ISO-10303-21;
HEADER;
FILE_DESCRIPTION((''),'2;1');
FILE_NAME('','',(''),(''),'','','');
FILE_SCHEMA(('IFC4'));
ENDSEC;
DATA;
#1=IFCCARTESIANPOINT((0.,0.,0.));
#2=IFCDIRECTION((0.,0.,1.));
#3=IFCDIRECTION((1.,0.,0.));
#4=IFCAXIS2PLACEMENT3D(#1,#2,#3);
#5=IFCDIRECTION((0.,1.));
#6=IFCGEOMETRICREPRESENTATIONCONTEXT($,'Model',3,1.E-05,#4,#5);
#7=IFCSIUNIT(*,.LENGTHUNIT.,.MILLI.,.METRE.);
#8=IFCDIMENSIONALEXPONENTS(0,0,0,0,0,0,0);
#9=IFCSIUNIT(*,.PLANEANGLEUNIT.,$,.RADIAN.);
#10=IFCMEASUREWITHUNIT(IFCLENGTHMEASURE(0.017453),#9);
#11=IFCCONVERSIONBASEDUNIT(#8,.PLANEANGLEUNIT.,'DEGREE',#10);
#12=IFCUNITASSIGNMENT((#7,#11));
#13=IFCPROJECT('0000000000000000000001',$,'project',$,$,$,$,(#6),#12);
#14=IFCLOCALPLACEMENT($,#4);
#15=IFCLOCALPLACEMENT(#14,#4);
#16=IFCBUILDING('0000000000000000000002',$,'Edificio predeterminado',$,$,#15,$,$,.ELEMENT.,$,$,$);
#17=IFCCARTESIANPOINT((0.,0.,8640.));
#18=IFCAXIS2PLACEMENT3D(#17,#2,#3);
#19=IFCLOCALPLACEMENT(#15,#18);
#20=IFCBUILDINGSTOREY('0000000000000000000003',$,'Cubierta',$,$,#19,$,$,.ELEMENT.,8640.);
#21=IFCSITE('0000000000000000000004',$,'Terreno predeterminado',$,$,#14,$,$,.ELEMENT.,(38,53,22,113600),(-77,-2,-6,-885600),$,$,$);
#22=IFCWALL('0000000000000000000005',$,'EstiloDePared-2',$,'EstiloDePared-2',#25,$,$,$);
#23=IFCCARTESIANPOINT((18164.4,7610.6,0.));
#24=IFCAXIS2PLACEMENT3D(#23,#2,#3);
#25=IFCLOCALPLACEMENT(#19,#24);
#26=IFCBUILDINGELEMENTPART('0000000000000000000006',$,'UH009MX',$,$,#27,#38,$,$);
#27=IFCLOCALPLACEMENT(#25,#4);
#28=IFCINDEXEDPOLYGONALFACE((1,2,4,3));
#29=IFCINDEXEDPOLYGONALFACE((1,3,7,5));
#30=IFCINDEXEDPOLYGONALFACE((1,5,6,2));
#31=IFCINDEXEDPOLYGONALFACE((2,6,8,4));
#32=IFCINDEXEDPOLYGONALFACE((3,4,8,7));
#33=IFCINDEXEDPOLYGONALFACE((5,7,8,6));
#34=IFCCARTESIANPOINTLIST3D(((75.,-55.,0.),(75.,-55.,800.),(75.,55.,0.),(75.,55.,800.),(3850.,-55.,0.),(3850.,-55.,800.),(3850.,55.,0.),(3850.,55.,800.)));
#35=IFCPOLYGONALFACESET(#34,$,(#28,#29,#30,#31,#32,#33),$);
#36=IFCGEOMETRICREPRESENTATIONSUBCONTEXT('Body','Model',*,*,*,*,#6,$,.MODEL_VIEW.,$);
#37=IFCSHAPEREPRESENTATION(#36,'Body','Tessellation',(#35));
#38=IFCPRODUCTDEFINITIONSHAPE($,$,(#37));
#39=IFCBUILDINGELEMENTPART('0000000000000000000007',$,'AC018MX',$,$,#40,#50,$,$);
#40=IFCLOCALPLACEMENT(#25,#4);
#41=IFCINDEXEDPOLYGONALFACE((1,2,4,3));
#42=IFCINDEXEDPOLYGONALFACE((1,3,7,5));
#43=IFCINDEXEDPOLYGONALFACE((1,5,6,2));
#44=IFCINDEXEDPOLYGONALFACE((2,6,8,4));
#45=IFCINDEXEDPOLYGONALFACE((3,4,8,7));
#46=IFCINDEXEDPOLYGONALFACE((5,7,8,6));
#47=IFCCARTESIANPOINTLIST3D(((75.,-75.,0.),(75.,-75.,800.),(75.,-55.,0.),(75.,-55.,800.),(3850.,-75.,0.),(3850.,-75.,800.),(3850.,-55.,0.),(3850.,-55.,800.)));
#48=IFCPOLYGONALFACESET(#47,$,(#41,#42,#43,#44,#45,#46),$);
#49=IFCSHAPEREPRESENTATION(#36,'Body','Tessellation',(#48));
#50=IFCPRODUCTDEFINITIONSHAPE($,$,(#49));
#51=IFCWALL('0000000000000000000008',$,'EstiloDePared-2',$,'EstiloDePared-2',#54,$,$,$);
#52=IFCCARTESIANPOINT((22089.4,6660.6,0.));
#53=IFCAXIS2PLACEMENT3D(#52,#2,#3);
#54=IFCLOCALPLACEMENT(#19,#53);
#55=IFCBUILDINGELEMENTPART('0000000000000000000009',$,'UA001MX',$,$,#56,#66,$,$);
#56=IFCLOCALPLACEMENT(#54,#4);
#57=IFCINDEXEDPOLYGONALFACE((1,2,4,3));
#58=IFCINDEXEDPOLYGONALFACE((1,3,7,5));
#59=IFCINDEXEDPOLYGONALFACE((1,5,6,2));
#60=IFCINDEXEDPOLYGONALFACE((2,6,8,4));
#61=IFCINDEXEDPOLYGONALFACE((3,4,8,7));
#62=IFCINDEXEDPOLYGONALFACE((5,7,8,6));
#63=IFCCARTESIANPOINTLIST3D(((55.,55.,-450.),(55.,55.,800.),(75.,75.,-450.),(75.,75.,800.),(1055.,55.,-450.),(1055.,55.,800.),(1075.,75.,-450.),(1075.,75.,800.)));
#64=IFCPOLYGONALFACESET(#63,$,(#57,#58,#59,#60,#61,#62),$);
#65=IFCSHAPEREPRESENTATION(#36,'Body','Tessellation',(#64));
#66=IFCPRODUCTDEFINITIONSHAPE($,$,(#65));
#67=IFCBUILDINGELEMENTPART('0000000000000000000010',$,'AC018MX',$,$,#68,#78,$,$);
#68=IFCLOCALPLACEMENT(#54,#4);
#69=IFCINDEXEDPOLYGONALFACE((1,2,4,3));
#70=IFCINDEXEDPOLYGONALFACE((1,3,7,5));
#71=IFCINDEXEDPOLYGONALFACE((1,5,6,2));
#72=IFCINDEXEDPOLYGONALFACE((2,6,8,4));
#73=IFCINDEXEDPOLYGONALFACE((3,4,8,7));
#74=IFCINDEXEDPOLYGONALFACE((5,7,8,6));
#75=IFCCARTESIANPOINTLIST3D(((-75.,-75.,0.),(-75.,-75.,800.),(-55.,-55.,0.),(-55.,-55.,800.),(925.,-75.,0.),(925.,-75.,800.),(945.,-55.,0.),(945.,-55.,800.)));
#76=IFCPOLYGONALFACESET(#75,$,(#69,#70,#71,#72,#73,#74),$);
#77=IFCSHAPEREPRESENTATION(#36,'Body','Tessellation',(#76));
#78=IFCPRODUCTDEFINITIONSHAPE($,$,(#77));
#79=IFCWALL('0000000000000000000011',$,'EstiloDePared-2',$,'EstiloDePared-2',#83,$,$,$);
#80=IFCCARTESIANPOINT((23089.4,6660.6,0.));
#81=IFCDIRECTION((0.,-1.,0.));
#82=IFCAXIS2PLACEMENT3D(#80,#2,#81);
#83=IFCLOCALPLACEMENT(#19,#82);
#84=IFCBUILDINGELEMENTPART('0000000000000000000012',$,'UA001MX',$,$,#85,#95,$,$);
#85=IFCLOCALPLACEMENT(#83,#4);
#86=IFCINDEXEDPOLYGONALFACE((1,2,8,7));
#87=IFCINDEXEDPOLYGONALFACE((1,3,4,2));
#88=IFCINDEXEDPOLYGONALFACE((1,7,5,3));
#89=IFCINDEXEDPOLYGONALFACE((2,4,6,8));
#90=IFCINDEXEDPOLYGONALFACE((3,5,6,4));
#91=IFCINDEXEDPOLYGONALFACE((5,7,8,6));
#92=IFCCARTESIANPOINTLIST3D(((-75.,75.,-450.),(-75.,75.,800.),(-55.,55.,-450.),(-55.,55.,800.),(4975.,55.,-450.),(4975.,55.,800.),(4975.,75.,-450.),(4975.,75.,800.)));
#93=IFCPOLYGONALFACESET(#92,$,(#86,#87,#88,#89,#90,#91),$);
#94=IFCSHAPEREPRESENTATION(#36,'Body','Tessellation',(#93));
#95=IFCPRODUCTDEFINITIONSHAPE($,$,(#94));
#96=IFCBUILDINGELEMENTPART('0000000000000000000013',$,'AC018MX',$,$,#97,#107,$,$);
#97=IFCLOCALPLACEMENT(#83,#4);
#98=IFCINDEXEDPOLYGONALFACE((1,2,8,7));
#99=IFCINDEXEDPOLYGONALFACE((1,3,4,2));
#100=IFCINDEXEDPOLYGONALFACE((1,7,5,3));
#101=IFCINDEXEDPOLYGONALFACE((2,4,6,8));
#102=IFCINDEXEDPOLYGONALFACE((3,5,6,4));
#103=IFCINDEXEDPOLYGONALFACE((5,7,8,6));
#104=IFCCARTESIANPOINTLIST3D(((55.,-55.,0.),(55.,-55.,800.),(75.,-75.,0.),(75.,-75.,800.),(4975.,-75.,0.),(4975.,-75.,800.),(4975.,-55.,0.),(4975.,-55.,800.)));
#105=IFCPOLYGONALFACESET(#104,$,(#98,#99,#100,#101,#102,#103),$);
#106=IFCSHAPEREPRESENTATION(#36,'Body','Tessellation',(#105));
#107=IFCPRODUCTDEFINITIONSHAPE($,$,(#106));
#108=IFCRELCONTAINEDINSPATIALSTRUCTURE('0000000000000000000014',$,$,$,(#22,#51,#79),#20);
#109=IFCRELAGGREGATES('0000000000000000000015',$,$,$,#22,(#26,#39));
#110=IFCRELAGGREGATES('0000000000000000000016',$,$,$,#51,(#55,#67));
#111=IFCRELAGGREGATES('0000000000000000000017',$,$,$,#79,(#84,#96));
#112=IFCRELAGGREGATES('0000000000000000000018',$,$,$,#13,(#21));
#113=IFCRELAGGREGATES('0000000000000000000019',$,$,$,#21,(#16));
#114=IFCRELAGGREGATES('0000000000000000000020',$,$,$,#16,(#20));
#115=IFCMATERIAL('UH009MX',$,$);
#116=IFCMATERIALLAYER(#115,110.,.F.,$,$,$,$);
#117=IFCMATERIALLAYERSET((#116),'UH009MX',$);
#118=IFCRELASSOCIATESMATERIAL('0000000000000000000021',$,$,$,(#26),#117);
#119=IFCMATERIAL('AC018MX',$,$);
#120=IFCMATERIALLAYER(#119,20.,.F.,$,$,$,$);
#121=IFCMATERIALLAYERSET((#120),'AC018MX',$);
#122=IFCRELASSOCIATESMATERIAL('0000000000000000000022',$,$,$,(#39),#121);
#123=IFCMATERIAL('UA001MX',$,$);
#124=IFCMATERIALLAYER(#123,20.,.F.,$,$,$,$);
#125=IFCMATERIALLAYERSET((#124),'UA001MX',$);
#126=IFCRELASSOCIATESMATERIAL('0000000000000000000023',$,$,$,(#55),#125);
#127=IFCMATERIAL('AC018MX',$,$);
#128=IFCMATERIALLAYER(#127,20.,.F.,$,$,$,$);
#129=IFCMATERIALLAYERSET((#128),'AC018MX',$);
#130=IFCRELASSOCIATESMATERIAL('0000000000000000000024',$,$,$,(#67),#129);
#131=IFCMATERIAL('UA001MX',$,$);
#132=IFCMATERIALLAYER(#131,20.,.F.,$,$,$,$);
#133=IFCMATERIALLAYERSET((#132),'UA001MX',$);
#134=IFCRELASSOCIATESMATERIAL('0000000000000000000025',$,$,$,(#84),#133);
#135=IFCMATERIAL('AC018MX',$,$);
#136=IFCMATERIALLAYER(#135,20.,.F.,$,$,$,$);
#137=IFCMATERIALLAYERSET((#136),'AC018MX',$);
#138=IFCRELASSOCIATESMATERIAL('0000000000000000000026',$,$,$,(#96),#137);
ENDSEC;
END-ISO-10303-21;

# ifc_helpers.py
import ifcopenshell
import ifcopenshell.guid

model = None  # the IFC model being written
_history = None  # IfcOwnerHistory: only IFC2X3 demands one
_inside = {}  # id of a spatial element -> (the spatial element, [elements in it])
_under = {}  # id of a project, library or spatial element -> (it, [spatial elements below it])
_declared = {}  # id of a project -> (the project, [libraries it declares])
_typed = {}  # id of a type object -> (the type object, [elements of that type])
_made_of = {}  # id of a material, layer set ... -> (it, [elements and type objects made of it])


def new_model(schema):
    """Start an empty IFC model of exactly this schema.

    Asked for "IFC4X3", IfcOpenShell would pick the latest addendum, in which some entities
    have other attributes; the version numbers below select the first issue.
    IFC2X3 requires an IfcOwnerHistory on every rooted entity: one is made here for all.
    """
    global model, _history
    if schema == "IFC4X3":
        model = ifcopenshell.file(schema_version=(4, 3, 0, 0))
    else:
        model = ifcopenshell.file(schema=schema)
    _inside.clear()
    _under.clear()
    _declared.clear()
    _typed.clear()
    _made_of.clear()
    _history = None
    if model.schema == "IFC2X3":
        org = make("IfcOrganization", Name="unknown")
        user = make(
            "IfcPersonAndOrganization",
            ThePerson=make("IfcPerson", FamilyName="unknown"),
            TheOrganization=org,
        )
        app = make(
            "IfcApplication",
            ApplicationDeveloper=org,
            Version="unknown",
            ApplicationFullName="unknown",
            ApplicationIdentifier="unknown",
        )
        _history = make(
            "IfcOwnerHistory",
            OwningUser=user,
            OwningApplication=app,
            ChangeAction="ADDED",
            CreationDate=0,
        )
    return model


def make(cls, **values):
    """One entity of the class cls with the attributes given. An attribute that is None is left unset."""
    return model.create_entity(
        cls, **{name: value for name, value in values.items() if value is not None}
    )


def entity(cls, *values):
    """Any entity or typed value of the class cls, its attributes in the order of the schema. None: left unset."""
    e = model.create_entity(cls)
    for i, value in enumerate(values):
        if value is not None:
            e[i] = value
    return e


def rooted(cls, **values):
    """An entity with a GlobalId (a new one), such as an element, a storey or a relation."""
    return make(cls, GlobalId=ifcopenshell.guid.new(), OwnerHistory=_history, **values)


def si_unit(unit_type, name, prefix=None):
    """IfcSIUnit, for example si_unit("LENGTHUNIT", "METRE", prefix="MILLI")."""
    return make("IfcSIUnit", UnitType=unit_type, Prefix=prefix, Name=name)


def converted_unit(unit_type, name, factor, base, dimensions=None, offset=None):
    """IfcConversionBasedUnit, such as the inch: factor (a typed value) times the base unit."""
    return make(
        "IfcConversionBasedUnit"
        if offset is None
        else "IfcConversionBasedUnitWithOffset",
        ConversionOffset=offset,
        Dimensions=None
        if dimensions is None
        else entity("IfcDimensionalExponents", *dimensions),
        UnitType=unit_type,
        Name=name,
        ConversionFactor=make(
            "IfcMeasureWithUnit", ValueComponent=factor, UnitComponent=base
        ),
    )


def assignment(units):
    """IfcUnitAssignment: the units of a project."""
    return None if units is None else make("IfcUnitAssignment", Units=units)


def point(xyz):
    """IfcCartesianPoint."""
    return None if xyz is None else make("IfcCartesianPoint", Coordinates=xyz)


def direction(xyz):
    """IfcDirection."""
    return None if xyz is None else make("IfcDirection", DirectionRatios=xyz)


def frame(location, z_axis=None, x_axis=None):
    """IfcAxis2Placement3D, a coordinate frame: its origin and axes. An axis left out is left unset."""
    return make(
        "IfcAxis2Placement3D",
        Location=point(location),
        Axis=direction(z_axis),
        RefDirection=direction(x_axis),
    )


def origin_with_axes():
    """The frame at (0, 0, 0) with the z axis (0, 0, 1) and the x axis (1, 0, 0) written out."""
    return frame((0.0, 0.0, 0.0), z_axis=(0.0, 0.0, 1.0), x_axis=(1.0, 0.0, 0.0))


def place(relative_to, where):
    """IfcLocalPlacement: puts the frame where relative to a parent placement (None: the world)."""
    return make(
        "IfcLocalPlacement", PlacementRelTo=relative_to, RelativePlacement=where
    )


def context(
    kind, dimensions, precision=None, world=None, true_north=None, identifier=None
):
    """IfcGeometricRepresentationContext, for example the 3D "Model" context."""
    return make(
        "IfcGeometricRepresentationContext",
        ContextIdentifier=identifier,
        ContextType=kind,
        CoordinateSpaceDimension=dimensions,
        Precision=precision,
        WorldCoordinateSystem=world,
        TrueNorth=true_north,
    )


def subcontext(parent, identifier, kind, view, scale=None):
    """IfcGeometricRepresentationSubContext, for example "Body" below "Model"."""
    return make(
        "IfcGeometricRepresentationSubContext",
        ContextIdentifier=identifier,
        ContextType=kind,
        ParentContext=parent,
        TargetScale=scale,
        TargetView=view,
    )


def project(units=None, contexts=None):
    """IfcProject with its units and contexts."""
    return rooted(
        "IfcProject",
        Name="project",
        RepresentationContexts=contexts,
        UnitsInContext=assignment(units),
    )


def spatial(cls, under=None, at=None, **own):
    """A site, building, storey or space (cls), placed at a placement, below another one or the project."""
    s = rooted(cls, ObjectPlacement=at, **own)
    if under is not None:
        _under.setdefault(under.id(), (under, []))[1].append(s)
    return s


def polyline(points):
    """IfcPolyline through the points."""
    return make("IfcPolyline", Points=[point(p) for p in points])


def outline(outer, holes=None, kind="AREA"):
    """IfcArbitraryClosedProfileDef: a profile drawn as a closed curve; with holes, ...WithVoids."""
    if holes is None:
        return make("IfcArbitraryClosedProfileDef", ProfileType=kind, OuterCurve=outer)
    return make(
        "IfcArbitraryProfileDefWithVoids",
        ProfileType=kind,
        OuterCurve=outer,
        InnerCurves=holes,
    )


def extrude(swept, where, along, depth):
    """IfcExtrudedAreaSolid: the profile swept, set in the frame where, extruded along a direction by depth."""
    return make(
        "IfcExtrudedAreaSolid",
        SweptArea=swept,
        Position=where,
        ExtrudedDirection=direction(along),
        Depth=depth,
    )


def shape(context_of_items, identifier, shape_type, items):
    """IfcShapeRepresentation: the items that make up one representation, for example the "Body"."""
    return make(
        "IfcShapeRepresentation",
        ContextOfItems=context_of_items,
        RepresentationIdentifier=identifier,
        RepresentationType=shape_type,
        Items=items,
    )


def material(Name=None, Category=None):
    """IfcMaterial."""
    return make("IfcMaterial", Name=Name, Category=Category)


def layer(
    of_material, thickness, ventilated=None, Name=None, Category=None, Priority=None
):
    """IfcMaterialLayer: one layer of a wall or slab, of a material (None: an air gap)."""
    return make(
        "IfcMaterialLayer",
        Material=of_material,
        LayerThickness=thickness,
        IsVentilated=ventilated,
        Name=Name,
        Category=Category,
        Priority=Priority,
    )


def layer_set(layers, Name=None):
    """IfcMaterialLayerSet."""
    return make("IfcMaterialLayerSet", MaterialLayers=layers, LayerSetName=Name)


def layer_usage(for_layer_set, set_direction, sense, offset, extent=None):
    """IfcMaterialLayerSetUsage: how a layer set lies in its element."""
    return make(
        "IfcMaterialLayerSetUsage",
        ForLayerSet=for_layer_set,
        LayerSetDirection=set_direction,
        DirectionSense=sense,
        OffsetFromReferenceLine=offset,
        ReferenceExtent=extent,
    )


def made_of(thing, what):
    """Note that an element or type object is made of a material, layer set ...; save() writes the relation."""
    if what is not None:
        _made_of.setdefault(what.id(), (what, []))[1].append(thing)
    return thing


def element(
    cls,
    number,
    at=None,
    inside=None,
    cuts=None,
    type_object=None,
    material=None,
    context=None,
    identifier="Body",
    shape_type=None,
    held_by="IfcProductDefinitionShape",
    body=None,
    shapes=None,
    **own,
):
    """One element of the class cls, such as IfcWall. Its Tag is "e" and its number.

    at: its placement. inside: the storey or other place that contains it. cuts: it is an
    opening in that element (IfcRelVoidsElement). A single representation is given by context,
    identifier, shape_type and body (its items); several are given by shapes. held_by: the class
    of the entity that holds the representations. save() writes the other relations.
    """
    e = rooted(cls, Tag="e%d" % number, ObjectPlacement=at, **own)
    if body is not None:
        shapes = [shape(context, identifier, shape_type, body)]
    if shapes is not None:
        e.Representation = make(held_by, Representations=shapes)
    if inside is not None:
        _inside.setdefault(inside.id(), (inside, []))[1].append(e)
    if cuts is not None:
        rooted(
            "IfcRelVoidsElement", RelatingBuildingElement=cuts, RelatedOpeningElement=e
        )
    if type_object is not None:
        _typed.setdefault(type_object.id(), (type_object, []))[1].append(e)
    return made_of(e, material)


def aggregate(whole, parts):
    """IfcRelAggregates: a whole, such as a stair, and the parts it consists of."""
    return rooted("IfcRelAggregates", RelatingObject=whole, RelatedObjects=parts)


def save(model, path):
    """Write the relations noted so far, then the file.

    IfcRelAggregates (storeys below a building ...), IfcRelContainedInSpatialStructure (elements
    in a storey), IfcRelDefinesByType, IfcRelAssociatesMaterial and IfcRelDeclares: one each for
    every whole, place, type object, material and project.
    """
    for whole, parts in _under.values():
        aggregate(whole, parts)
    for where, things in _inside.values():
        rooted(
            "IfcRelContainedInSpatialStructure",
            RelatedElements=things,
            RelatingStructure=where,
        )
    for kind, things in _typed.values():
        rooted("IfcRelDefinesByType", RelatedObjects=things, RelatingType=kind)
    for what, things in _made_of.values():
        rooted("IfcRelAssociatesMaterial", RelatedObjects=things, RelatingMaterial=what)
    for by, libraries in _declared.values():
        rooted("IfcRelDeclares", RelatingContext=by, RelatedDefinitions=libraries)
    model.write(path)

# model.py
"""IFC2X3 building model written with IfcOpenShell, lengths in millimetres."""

from ifc_helpers import new_model, entity, si_unit, converted_unit, direction, frame, origin_with_axes, place, context, subcontext, project, spatial, polyline, outline, extrude, material, layer, layer_set, layer_usage, element, aggregate, save


model = new_model("IFC2X3")

# Units and contexts
model_context = context("Model", 3, precision=1e-05, world=origin_with_axes(), true_north=direction((0.0, 1.0)))
body_context = subcontext(model_context, "Body", "Model", "MODEL_VIEW")
ifc_project = project(units=[si_unit("LENGTHUNIT", "METRE", prefix="MILLI"), converted_unit("PLANEANGLEUNIT", "DEGREE", entity("IfcLengthMeasure", 0.017453), si_unit("PLANEANGLEUNIT", "RADIAN"), dimensions=[0, 0, 0, 0, 0, 0, 0])], contexts=[model_context])

# Site, building, storey
site_placement = place(None, origin_with_axes())
site = spatial("IfcSite", under=ifc_project, at=site_placement, Name="Terreno predeterminado", CompositionType="ELEMENT", RefLatitude=(38, 53, 22, 113600), RefLongitude=(-77, -2, -6, -885600))
building_placement = place(site_placement, origin_with_axes())
building = spatial("IfcBuilding", under=site, at=building_placement, Name="Edificio predeterminado", CompositionType="ELEMENT")
storey_placement = place(building_placement, frame((0.0, 0.0, 8640.0), z_axis=(0.0, 0.0, 1.0), x_axis=(1.0, 0.0, 0.0)))
storey = spatial("IfcBuildingStorey", under=building, at=storey_placement, Name="Cubierta", CompositionType="ELEMENT", Elevation=8640.0)

# Walls, building element parts
wall_1_placement = place(storey_placement, frame((18164.4, 7610.6, 0.0), z_axis=(0.0, 0.0, 1.0), x_axis=(1.0, 0.0, 0.0)))
wall_1 = element("IfcWall", 1, at=wall_1_placement, inside=storey, Name="EstiloDePared-2", ObjectType="EstiloDePared-2")
ifc_material_1 = material(Name="UH009MX")
ifc_layer_1 = layer(ifc_material_1, 110.0, ventilated=False)
ifc_layer_set_1 = layer_set([ifc_layer_1], Name="UH009MX")
ifc_layer_usage_1 = layer_usage(ifc_layer_set_1, "AXIS2", "NEGATIVE", -55.0)
building_element_part_1_placement = place(wall_1_placement, origin_with_axes())
building_element_part_1 = element("IfcBuildingElementPart", 2, at=building_element_part_1_placement, material=ifc_layer_usage_1, Name="UH009MX", context=body_context, shape_type="SweptSolid", body=[
    extrude(outline(polyline([(3850.0, 55.0), (3850.0, -55.0), (75.0, -55.0), (75.0, 55.0), (3850.0, 55.0)])), origin_with_axes(), (0.0, 0.0, 1.0), 800.0),
])
ifc_material_2 = material(Name="AC018MX")
ifc_layer_2 = layer(ifc_material_2, 20.0, ventilated=False)
ifc_layer_set_2 = layer_set([ifc_layer_2], Name="AC018MX")
ifc_layer_usage_2 = layer_usage(ifc_layer_set_2, "AXIS2", "NEGATIVE", 55.0)
building_element_part_2_placement = place(wall_1_placement, origin_with_axes())
building_element_part_2 = element("IfcBuildingElementPart", 3, at=building_element_part_2_placement, material=ifc_layer_usage_2, Name="AC018MX", context=body_context, shape_type="SweptSolid", body=[
    extrude(outline(polyline([(3850.0, -55.0), (3850.0, -75.0), (75.0, -75.0), (75.0, -55.0), (3850.0, -55.0)])), origin_with_axes(), (0.0, 0.0, 1.0), 800.0),
])
aggregate(wall_1, [building_element_part_1, building_element_part_2])
wall_2_placement = place(storey_placement, frame((22089.4, 6660.6, 0.0), z_axis=(0.0, 0.0, 1.0), x_axis=(1.0, 0.0, 0.0)))
wall_2 = element("IfcWall", 4, at=wall_2_placement, inside=storey, Name="EstiloDePared-2", ObjectType="EstiloDePared-2")
ifc_material_3 = material(Name="UA001MX")
ifc_layer_3 = layer(ifc_material_3, 20.0, ventilated=False)
ifc_layer_set_3 = layer_set([ifc_layer_3], Name="UA001MX")
ifc_layer_usage_3 = layer_usage(ifc_layer_set_3, "AXIS2", "NEGATIVE", -75.0)
building_element_part_3_placement = place(wall_2_placement, origin_with_axes())
building_element_part_3 = element("IfcBuildingElementPart", 5, at=building_element_part_3_placement, material=ifc_layer_usage_3, Name="UA001MX", context=body_context, shape_type="SweptSolid", body=[
    extrude(outline(polyline([(1075.0, 75.0), (1055.0, 55.0), (55.0, 55.0), (75.0, 75.0), (1075.0, 75.0)])), frame((0.0, 0.0, -450.0), z_axis=(0.0, 0.0, 1.0), x_axis=(1.0, 0.0, 0.0)), (0.0, 0.0, 1.0), 1250.0),
])
ifc_material_4 = material(Name="AC018MX")
ifc_layer_4 = layer(ifc_material_4, 20.0, ventilated=False)
ifc_layer_set_4 = layer_set([ifc_layer_4], Name="AC018MX")
ifc_layer_usage_4 = layer_usage(ifc_layer_set_4, "AXIS2", "NEGATIVE", 55.0)
building_element_part_4_placement = place(wall_2_placement, origin_with_axes())
building_element_part_4 = element("IfcBuildingElementPart", 6, at=building_element_part_4_placement, material=ifc_layer_usage_4, Name="AC018MX", context=body_context, shape_type="SweptSolid", body=[
    extrude(outline(polyline([(945.0, -55.0), (925.0, -75.0), (-75.0, -75.0), (-55.0, -55.0), (945.0, -55.0)])), origin_with_axes(), (0.0, 0.0, 1.0), 800.0),
])
aggregate(wall_2, [building_element_part_3, building_element_part_4])
wall_3_placement = place(storey_placement, frame((23089.4, 6660.6, 0.0), z_axis=(0.0, 0.0, 1.0), x_axis=(0.0, -1.0, 0.0)))
wall_3 = element("IfcWall", 7, at=wall_3_placement, inside=storey, Name="EstiloDePared-2", ObjectType="EstiloDePared-2")
ifc_material_5 = material(Name="UA001MX")
ifc_layer_5 = layer(ifc_material_5, 20.0, ventilated=False)
ifc_layer_set_5 = layer_set([ifc_layer_5], Name="UA001MX")
ifc_layer_usage_5 = layer_usage(ifc_layer_set_5, "AXIS2", "NEGATIVE", -75.0)
building_element_part_5_placement = place(wall_3_placement, origin_with_axes())
building_element_part_5 = element("IfcBuildingElementPart", 8, at=building_element_part_5_placement, material=ifc_layer_usage_5, Name="UA001MX", context=body_context, shape_type="SweptSolid", body=[
    extrude(outline(polyline([(4975.0, 75.0), (4975.0, 55.0), (-55.0, 55.0), (-75.0, 75.0), (4975.0, 75.0)])), frame((0.0, 0.0, -450.0), z_axis=(0.0, 0.0, 1.0), x_axis=(1.0, 0.0, 0.0)), (0.0, 0.0, 1.0), 1250.0),
])
ifc_material_6 = material(Name="AC018MX")
ifc_layer_6 = layer(ifc_material_6, 20.0, ventilated=False)
ifc_layer_set_6 = layer_set([ifc_layer_6], Name="AC018MX")
ifc_layer_usage_6 = layer_usage(ifc_layer_set_6, "AXIS2", "NEGATIVE", 55.0)
building_element_part_6_placement = place(wall_3_placement, origin_with_axes())
building_element_part_6 = element("IfcBuildingElementPart", 9, at=building_element_part_6_placement, material=ifc_layer_usage_6, Name="AC018MX", context=body_context, shape_type="SweptSolid", body=[
    extrude(outline(polyline([(4975.0, -55.0), (4975.0, -75.0), (75.0, -75.0), (55.0, -55.0), (4975.0, -55.0)])), origin_with_axes(), (0.0, 0.0, 1.0), 800.0),
])
aggregate(wall_3, [building_element_part_5, building_element_part_6])

save(model, "model.ifc")
